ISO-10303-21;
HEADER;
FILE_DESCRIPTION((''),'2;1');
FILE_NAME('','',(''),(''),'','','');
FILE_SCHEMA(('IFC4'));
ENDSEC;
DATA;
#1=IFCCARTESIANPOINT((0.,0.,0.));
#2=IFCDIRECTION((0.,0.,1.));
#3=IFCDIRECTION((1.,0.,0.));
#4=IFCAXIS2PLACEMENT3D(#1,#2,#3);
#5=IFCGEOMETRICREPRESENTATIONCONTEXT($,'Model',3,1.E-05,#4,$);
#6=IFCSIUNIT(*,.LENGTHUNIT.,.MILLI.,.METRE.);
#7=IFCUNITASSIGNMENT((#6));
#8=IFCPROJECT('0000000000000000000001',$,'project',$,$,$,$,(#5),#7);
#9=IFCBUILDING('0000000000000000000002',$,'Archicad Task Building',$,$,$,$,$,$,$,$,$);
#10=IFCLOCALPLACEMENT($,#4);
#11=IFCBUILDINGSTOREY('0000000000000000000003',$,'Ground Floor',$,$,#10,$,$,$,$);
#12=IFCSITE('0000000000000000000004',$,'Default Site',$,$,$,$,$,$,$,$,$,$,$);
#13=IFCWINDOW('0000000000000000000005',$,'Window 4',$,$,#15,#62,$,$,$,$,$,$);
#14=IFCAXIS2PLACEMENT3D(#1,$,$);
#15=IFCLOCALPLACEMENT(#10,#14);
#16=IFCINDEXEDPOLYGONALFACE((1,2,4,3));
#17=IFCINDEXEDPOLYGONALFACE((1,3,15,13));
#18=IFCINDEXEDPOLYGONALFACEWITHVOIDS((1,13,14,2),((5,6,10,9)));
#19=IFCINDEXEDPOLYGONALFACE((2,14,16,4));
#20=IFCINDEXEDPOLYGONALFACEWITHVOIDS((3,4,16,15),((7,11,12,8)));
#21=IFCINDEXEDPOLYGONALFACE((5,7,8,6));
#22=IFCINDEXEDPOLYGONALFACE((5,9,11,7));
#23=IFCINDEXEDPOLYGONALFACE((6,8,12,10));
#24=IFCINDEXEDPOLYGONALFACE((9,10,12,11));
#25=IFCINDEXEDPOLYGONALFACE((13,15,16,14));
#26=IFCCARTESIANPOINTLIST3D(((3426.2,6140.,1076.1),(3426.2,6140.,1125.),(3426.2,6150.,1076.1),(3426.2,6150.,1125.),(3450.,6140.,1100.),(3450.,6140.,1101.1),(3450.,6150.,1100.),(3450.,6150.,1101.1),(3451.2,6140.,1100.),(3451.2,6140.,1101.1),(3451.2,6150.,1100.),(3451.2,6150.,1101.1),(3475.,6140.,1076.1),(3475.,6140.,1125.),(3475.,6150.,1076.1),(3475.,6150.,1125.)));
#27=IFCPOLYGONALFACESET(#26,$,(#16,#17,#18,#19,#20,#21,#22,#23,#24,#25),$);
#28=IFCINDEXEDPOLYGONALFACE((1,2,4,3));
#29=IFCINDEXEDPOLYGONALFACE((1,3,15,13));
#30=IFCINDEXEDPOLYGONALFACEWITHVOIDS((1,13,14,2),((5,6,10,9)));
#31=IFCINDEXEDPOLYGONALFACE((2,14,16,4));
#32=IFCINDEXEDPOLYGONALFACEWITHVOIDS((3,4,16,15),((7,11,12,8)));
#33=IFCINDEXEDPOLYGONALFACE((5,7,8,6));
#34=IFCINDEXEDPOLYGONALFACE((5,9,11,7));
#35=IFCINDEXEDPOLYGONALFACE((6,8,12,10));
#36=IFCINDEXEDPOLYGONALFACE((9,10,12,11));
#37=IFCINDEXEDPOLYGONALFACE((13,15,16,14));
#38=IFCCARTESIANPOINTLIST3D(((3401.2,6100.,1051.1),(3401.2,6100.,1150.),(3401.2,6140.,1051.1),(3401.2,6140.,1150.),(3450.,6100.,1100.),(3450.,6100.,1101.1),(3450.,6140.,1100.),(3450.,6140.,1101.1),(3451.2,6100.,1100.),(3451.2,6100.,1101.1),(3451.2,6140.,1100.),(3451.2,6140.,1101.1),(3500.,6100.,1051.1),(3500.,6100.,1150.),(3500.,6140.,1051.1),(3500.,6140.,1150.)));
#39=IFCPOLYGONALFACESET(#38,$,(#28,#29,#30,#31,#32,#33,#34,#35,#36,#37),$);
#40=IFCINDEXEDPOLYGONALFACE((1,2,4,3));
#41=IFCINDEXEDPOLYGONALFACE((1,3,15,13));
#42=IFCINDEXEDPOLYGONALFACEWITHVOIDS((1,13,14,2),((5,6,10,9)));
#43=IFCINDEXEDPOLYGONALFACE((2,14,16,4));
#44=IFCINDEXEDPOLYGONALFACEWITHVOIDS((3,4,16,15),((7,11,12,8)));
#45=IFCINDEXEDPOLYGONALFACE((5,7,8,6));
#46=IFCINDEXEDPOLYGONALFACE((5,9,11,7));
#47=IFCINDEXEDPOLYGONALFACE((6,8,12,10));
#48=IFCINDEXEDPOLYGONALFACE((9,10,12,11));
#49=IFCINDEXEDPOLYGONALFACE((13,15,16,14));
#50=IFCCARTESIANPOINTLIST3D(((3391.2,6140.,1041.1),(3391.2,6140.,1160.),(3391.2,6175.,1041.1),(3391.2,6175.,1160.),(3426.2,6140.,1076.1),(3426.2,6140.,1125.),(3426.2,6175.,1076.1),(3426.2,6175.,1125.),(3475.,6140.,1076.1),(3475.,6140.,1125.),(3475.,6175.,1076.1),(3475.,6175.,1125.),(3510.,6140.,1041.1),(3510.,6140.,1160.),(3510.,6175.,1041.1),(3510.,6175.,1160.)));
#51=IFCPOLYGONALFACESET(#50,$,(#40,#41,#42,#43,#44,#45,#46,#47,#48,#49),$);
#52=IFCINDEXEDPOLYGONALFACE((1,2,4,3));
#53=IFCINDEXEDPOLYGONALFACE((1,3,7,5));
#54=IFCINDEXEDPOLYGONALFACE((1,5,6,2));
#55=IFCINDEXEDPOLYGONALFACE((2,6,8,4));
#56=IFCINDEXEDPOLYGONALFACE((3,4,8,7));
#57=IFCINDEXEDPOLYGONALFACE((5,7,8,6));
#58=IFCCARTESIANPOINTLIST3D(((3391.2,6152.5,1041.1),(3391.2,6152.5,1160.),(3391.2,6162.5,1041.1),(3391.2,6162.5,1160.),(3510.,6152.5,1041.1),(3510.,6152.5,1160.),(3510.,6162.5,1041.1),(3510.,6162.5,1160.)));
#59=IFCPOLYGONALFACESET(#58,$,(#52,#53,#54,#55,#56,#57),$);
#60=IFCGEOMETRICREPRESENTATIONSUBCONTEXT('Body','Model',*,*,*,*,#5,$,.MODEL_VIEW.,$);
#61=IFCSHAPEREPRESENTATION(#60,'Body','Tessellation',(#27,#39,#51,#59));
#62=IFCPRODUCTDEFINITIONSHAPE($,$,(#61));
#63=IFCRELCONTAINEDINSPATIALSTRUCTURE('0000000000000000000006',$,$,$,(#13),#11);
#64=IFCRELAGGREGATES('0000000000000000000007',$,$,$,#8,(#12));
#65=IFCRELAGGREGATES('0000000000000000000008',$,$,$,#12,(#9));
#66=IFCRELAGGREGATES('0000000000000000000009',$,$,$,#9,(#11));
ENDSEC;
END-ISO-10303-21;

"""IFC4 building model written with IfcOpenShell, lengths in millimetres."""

from ifc_helpers import new_model, si_unit, frame, origin_with_axes, place, context, subcontext, project, spatial, line, indexed_curve, outline, extrude, element, save


model = new_model("IFC4")

# Units and contexts
model_context = context("Model", 3, precision=1e-05, world=origin_with_axes())
body_context = subcontext(model_context, "Body", "Model", "MODEL_VIEW")
ifc_project = project(units=[si_unit("LENGTHUNIT", "METRE", prefix="MILLI")], contexts=[model_context])

# Site, building, storey
site = spatial("IfcSite", under=ifc_project, Name="Default Site")
building = spatial("IfcBuilding", under=site, Name="Archicad Task Building")
storey_placement = place(None, origin_with_axes())
storey = spatial("IfcBuildingStorey", under=building, at=storey_placement, Name="Ground Floor")

# Window
for number, where, z_axis, x_axis, name in (
    (1, (3450.0, 6050.0, 1100.0), (0.0, 0.0, 1.0), (1.0, 0.0, 0.0), "Window 4"),
):
    element("IfcWindow", number, at=place(storey_placement, frame(where, z_axis=z_axis, x_axis=x_axis)), inside=storey, Name=name, context=body_context, shape_type="SweptSolid", body=[
        extrude(outline(indexed_curve([(0.0, 0.0), (1.2, 0.0), (1.2, 1.1), (0.0, 1.1)], segments=[line(1, 2, 3, 4, 1)]), holes=[indexed_curve([(25.0, 25.0), (-23.8, 25.0), (-23.8, -23.9), (25.0, -23.9)], segments=[line(1, 2, 3, 4, 1)])]), frame((0.0, 90.0, 0.0), z_axis=(0.0, -1.0, 0.0), x_axis=(1.0, 0.0, 0.0)), (0.0, 0.0, -1.0), 10.0),
        extrude(outline(indexed_curve([(0.0, 0.0), (1.2, 0.0), (1.2, 1.1), (0.0, 1.1)], segments=[line(1, 2, 3, 4, 1)]), holes=[indexed_curve([(50.0, 50.0), (-48.8, 50.0), (-48.8, -48.9), (50.0, -48.9)], segments=[line(1, 2, 3, 4, 1)])]), frame((0.0, 50.0, 0.0), z_axis=(0.0, -1.0, 0.0), x_axis=(1.0, 0.0, 0.0)), (0.0, 0.0, -1.0), 40.0),
        extrude(outline(indexed_curve([(0.0, 0.0), (-48.8, 0.0), (-48.8, -48.9), (0.0, -48.9)], segments=[line(1, 2, 3, 4, 1)]), holes=[indexed_curve([(35.0, 35.0), (-83.8, 35.0), (-83.8, -83.9), (35.0, -83.9)], segments=[line(1, 2, 3, 4, 1)])]), frame((25.0, 90.0, 25.0), z_axis=(0.0, -1.0, 0.0), x_axis=(1.0, 0.0, 0.0)), (0.0, 0.0, -1.0), 35.0),
        extrude(outline(indexed_curve([(35.0, 35.0), (-83.8, 35.0), (-83.8, -83.9), (35.0, -83.9)], segments=[line(1, 2, 3, 4, 1)])), frame((25.0, 102.5, 25.0), z_axis=(0.0, -1.0, 0.0), x_axis=(1.0, 0.0, 0.0)), (0.0, 0.0, -1.0), 10.0),
    ])

save(model, "model.ifc")
